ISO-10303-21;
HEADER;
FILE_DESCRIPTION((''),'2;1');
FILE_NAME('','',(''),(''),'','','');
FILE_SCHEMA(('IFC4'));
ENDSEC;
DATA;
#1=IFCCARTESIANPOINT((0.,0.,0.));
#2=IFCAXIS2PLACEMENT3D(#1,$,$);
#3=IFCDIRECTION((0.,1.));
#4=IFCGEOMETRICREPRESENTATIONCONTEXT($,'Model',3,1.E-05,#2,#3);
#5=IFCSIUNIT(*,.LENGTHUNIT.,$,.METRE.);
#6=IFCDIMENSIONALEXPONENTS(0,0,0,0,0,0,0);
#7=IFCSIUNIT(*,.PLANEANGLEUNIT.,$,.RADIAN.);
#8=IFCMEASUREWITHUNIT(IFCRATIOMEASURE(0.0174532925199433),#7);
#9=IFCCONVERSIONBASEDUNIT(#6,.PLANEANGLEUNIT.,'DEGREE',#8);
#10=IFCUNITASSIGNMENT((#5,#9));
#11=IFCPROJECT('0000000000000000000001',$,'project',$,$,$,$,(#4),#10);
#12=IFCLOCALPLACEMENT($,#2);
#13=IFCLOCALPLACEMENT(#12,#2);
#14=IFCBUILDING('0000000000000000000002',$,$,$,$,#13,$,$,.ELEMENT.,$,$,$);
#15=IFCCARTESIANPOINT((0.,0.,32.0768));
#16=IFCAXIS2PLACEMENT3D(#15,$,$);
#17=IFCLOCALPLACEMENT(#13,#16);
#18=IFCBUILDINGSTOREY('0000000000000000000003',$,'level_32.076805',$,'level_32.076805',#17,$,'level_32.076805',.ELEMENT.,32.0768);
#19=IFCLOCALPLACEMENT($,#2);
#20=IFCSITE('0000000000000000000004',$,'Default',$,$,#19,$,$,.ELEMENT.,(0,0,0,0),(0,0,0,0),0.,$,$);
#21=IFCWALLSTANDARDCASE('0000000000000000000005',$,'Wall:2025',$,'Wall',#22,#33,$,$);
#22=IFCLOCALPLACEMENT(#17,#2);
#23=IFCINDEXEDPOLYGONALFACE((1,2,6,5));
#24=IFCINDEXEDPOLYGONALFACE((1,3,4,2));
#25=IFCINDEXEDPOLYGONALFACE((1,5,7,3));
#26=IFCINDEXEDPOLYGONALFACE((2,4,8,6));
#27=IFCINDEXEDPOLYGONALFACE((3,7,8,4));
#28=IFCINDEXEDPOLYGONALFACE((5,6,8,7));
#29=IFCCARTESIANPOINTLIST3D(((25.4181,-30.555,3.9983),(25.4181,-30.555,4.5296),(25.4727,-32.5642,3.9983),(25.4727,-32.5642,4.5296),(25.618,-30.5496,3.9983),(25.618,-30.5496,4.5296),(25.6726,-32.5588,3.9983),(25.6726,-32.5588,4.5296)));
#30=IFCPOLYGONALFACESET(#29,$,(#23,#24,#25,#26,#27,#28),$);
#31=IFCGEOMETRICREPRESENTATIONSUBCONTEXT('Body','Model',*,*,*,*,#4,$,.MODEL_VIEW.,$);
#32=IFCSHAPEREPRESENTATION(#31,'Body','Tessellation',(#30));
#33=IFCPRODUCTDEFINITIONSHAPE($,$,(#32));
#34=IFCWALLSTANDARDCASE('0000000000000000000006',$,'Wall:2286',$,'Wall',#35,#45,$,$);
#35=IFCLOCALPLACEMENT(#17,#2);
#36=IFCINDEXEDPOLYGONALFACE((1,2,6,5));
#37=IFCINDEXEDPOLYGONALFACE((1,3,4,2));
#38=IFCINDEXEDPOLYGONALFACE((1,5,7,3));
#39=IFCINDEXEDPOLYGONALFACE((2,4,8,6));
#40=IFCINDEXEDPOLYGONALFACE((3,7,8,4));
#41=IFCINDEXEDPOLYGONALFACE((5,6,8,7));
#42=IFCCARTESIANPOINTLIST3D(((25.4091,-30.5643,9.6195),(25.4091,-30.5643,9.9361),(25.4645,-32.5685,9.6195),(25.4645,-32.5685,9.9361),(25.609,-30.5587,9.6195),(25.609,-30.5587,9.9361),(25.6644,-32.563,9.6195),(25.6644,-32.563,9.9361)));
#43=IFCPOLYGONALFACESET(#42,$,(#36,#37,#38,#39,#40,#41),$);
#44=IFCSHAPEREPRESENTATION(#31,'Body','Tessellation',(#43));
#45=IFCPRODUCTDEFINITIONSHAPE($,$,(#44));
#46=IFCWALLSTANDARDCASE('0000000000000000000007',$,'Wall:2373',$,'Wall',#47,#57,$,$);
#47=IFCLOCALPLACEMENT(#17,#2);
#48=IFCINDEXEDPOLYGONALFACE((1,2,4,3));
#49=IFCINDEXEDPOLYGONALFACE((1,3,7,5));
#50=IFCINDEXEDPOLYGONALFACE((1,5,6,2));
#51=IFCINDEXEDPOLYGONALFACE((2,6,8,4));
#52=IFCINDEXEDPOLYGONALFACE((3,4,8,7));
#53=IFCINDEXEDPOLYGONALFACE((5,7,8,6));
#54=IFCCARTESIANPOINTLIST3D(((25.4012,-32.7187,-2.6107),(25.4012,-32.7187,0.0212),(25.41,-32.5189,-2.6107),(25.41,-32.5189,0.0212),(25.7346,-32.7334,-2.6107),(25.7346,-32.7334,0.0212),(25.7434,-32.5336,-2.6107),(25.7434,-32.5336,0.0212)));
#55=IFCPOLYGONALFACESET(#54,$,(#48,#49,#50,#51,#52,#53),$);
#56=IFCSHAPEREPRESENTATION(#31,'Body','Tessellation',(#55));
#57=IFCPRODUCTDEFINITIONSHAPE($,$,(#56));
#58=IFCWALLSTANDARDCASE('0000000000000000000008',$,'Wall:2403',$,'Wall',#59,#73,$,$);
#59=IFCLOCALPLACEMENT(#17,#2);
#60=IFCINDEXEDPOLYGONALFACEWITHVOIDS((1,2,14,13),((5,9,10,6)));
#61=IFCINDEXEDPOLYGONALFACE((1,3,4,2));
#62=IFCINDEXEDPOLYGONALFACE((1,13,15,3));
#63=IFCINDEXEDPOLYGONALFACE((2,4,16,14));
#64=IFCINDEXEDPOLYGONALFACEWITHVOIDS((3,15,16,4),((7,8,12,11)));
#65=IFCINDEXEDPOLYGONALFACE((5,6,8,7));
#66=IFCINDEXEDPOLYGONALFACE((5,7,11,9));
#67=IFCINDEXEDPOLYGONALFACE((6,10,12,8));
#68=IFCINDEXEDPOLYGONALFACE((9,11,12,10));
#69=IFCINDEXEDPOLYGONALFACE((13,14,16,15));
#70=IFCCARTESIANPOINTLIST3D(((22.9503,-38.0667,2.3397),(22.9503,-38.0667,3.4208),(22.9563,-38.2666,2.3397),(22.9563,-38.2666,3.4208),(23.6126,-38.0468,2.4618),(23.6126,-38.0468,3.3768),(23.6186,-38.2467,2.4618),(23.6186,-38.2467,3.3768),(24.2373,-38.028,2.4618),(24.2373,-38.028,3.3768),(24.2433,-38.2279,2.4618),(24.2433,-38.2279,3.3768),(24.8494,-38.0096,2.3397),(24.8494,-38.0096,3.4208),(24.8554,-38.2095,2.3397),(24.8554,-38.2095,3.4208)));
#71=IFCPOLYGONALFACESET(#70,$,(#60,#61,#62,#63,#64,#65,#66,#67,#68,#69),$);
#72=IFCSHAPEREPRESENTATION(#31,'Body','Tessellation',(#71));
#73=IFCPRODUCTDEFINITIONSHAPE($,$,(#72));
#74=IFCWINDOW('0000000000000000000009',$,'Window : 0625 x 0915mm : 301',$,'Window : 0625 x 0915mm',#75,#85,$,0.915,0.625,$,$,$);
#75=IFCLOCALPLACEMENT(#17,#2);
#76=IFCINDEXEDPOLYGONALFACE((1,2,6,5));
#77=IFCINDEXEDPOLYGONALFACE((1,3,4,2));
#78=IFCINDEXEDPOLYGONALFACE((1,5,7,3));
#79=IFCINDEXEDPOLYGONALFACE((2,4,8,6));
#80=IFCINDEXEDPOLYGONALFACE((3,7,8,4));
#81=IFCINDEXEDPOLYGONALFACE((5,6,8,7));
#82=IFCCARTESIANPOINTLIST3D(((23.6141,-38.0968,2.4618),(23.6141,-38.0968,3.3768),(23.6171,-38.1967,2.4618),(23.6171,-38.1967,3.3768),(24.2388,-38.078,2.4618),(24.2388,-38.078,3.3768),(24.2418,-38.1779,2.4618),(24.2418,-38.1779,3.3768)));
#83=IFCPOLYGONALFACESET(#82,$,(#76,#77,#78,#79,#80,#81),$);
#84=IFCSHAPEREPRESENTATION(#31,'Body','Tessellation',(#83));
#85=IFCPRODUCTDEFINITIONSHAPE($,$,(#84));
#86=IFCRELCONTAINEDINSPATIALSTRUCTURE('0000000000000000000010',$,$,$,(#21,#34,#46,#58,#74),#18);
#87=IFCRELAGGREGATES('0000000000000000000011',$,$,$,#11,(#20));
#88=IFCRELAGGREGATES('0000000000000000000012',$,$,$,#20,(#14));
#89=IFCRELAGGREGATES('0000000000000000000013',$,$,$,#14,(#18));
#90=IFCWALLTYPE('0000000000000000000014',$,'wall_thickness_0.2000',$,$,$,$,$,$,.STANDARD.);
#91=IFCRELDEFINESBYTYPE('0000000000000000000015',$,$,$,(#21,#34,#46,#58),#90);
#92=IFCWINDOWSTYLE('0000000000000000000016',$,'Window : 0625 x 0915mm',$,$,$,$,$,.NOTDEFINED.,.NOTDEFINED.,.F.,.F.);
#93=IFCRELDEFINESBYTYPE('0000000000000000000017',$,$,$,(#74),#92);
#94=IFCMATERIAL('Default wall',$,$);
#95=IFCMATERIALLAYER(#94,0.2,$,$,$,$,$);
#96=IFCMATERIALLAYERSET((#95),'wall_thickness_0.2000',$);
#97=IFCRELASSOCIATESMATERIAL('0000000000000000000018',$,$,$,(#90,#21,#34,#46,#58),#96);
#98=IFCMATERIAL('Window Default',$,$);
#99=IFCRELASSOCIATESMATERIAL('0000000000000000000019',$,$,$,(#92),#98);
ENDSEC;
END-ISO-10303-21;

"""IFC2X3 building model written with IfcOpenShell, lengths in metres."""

from ifc_helpers import new_model, entity, si_unit, converted_unit, direction, frame, frame_2d, origin, origin_2d_with_axis, place, context, subcontext, project, spatial, polyline, rectangle, outline, extrude, source, transform, mapped, material, layer, layer_set, layer_usage, type_object, type_shapes, element, fill, save


model = new_model("IFC2X3")

# Units and contexts
model_context = context("Model", 3, precision=1e-05, world=origin(), true_north=direction((0.0, 1.0)))
body_context = subcontext(model_context, "Body", "Model", "MODEL_VIEW")
ifc_project = project(units=[si_unit("LENGTHUNIT", "METRE"), converted_unit("PLANEANGLEUNIT", "DEGREE", entity("IfcRatioMeasure", 0.0174532925199433), si_unit("PLANEANGLEUNIT", "RADIAN"), dimensions=[0, 0, 0, 0, 0, 0, 0])], contexts=[model_context])

# Site, building, storey
site_placement = place(None, origin())
site = spatial("IfcSite", under=ifc_project, at=site_placement, Name="Default", CompositionType="ELEMENT", RefLatitude=(0, 0, 0, 0), RefLongitude=(0, 0, 0, 0), RefElevation=0.0)
placement_1 = place(None, origin())
building_placement = place(placement_1, origin())
building = spatial("IfcBuilding", under=site, at=building_placement, CompositionType="ELEMENT")
storey_placement = place(building_placement, frame((0.0, 0.0, 32.0768)))
storey = spatial("IfcBuildingStorey", under=building, at=storey_placement, Name="level_32.076805", ObjectType="level_32.076805", LongName="level_32.076805", CompositionType="ELEMENT", Elevation=32.0768)

# Shared definitions
ifc_material_1 = material(Name="Default wall")
ifc_layer = layer(ifc_material_1, 0.2)
ifc_layer_set = layer_set([ifc_layer], Name="wall_thickness_0.2000")
ifc_layer_usage = layer_usage(ifc_layer_set, "AXIS2", "POSITIVE", -0.1)
wall_type = type_object("IfcWallType", Name="wall_thickness_0.2000", PredefinedType="STANDARD", material=ifc_layer_set)
ifc_material_2 = material(Name="Window Default")

# Walls
placement_2 = place(building_placement, frame((0.0, 0.0, 36.0751)))
wall_1_placement = place(placement_2, frame((25.5181, -30.5523, 0.0), z_axis=(0.0, 0.0, 1.0), x_axis=(0.027167, -0.999631, 0.0)))
element("IfcWallStandardCase", 1, at=wall_1_placement, inside=storey, type_object=wall_type, material=ifc_layer_usage, Name="Wall:2025", ObjectType="Wall", context=body_context, shape_type="SweptSolid", body=[
    extrude(outline(polyline([(2.01, -0.1), (2.01, 0.1), (0.0, 0.1), (0.0, -0.1), (2.01, -0.1)])), origin(), (0.0, 0.0, 1.0), 0.5313),
])
placement_3 = place(building_placement, frame((0.0, 0.0, 41.6963)))
wall_2_placement = place(placement_3, frame((25.509, -30.5615, 0.0), z_axis=(0.0, 0.0, 1.0), x_axis=(0.027665, -0.999617, 0.0)))
element("IfcWallStandardCase", 2, at=wall_2_placement, inside=storey, type_object=wall_type, material=ifc_layer_usage, Name="Wall:2286", ObjectType="Wall", context=body_context, shape_type="SweptSolid", body=[
    extrude(outline(polyline([(2.005, -0.1), (2.005, 0.1), (0.0, 0.1), (0.0, -0.1), (2.005, -0.1)])), origin(), (0.0, 0.0, 1.0), 0.3166),
])
placement_4 = place(building_placement, frame((0.0, 0.0, 29.4661)))
wall_3_placement = place(placement_4, frame((25.4056, -32.6188, 0.0), z_axis=(0.0, 0.0, 1.0), x_axis=(0.999031, -0.044016, 0.0)))
element("IfcWallStandardCase", 3, at=wall_3_placement, inside=storey, type_object=wall_type, material=ifc_layer_usage, Name="Wall:2373", ObjectType="Wall", context=body_context, shape_type="SweptSolid", body=[
    extrude(outline(polyline([(0.3337, -0.1), (0.3337, 0.1), (0.0, 0.1), (0.0, -0.1), (0.3337, -0.1)])), origin(), (0.0, 0.0, 1.0), 2.632),
])

# Wall, opening, window
placement_5 = place(building_placement, frame((0.0, 0.0, 34.4165)))
wall_4_placement = place(placement_5, frame((22.9533, -38.1666, 0.0), z_axis=(0.0, 0.0, 1.0), x_axis=(0.999548, 0.030058, 0.0)))
wall_4 = element("IfcWallStandardCase", 4, at=wall_4_placement, inside=storey, type_object=wall_type, material=ifc_layer_usage, Name="Wall:2403", ObjectType="Wall", context=body_context, shape_type="SweptSolid", body=[
    extrude(outline(polyline([(1.9, -0.1), (1.9, 0.1), (0.0, 0.1), (0.0, -0.1), (1.9, -0.1)])), origin(), (0.0, 0.0, 1.0), 1.081),
])
opening_1_placement = place(wall_4_placement, frame((0.6626, -0.1, 0.1221)))
opening_1 = element("IfcOpeningElement", 5, at=opening_1_placement, cuts=wall_4, ObjectType="Opening", context=body_context, shape_type="SweptSolid", body=[
    extrude(rectangle(XDim=0.625, YDim=0.915, at=frame_2d((0.4575, 0.3125), x_axis=(0.0, 1.0))), frame((0.0, 0.0, 0.0), z_axis=(0.0, 1.0, 0.0), x_axis=(0.0, 0.0, 1.0)), (0.0, 0.0, 1.0), 0.2),
])
window_style_1 = type_object("IfcWindowStyle", Name="Window : 0625 x 0915mm", ConstructionType="NOTDEFINED", OperationType="NOTDEFINED", ParameterTakesPrecedence=False, Sizeable=False, material=ifc_material_2)
shared_shape_1 = source(origin(), body_context, "Body", "SweptSolid", [
    extrude(rectangle(XDim=0.1, YDim=0.625, at=origin_2d_with_axis()), frame((0.3125, 0.1, 0.0), z_axis=(0.0, 0.0, 1.0), x_axis=(0.0, 1.0, 0.0)), (0.0, 0.0, 1.0), 0.915),
])
type_shapes(window_style_1, [shared_shape_1])
window_1_placement = place(opening_1_placement, origin())
window_1 = element("IfcWindow", 6, at=window_1_placement, inside=storey, type_object=window_style_1, Name="Window : 0625 x 0915mm : 301", ObjectType="Window : 0625 x 0915mm", OverallHeight=0.915, OverallWidth=0.625, context=body_context, shape_type="MappedRepresentation", body=[
    mapped(shared_shape_1, transform((0.0, 0.0, 0.0), scale=1.0)),
])
fill(opening_1, window_1)

save(model, "model.ifc")
